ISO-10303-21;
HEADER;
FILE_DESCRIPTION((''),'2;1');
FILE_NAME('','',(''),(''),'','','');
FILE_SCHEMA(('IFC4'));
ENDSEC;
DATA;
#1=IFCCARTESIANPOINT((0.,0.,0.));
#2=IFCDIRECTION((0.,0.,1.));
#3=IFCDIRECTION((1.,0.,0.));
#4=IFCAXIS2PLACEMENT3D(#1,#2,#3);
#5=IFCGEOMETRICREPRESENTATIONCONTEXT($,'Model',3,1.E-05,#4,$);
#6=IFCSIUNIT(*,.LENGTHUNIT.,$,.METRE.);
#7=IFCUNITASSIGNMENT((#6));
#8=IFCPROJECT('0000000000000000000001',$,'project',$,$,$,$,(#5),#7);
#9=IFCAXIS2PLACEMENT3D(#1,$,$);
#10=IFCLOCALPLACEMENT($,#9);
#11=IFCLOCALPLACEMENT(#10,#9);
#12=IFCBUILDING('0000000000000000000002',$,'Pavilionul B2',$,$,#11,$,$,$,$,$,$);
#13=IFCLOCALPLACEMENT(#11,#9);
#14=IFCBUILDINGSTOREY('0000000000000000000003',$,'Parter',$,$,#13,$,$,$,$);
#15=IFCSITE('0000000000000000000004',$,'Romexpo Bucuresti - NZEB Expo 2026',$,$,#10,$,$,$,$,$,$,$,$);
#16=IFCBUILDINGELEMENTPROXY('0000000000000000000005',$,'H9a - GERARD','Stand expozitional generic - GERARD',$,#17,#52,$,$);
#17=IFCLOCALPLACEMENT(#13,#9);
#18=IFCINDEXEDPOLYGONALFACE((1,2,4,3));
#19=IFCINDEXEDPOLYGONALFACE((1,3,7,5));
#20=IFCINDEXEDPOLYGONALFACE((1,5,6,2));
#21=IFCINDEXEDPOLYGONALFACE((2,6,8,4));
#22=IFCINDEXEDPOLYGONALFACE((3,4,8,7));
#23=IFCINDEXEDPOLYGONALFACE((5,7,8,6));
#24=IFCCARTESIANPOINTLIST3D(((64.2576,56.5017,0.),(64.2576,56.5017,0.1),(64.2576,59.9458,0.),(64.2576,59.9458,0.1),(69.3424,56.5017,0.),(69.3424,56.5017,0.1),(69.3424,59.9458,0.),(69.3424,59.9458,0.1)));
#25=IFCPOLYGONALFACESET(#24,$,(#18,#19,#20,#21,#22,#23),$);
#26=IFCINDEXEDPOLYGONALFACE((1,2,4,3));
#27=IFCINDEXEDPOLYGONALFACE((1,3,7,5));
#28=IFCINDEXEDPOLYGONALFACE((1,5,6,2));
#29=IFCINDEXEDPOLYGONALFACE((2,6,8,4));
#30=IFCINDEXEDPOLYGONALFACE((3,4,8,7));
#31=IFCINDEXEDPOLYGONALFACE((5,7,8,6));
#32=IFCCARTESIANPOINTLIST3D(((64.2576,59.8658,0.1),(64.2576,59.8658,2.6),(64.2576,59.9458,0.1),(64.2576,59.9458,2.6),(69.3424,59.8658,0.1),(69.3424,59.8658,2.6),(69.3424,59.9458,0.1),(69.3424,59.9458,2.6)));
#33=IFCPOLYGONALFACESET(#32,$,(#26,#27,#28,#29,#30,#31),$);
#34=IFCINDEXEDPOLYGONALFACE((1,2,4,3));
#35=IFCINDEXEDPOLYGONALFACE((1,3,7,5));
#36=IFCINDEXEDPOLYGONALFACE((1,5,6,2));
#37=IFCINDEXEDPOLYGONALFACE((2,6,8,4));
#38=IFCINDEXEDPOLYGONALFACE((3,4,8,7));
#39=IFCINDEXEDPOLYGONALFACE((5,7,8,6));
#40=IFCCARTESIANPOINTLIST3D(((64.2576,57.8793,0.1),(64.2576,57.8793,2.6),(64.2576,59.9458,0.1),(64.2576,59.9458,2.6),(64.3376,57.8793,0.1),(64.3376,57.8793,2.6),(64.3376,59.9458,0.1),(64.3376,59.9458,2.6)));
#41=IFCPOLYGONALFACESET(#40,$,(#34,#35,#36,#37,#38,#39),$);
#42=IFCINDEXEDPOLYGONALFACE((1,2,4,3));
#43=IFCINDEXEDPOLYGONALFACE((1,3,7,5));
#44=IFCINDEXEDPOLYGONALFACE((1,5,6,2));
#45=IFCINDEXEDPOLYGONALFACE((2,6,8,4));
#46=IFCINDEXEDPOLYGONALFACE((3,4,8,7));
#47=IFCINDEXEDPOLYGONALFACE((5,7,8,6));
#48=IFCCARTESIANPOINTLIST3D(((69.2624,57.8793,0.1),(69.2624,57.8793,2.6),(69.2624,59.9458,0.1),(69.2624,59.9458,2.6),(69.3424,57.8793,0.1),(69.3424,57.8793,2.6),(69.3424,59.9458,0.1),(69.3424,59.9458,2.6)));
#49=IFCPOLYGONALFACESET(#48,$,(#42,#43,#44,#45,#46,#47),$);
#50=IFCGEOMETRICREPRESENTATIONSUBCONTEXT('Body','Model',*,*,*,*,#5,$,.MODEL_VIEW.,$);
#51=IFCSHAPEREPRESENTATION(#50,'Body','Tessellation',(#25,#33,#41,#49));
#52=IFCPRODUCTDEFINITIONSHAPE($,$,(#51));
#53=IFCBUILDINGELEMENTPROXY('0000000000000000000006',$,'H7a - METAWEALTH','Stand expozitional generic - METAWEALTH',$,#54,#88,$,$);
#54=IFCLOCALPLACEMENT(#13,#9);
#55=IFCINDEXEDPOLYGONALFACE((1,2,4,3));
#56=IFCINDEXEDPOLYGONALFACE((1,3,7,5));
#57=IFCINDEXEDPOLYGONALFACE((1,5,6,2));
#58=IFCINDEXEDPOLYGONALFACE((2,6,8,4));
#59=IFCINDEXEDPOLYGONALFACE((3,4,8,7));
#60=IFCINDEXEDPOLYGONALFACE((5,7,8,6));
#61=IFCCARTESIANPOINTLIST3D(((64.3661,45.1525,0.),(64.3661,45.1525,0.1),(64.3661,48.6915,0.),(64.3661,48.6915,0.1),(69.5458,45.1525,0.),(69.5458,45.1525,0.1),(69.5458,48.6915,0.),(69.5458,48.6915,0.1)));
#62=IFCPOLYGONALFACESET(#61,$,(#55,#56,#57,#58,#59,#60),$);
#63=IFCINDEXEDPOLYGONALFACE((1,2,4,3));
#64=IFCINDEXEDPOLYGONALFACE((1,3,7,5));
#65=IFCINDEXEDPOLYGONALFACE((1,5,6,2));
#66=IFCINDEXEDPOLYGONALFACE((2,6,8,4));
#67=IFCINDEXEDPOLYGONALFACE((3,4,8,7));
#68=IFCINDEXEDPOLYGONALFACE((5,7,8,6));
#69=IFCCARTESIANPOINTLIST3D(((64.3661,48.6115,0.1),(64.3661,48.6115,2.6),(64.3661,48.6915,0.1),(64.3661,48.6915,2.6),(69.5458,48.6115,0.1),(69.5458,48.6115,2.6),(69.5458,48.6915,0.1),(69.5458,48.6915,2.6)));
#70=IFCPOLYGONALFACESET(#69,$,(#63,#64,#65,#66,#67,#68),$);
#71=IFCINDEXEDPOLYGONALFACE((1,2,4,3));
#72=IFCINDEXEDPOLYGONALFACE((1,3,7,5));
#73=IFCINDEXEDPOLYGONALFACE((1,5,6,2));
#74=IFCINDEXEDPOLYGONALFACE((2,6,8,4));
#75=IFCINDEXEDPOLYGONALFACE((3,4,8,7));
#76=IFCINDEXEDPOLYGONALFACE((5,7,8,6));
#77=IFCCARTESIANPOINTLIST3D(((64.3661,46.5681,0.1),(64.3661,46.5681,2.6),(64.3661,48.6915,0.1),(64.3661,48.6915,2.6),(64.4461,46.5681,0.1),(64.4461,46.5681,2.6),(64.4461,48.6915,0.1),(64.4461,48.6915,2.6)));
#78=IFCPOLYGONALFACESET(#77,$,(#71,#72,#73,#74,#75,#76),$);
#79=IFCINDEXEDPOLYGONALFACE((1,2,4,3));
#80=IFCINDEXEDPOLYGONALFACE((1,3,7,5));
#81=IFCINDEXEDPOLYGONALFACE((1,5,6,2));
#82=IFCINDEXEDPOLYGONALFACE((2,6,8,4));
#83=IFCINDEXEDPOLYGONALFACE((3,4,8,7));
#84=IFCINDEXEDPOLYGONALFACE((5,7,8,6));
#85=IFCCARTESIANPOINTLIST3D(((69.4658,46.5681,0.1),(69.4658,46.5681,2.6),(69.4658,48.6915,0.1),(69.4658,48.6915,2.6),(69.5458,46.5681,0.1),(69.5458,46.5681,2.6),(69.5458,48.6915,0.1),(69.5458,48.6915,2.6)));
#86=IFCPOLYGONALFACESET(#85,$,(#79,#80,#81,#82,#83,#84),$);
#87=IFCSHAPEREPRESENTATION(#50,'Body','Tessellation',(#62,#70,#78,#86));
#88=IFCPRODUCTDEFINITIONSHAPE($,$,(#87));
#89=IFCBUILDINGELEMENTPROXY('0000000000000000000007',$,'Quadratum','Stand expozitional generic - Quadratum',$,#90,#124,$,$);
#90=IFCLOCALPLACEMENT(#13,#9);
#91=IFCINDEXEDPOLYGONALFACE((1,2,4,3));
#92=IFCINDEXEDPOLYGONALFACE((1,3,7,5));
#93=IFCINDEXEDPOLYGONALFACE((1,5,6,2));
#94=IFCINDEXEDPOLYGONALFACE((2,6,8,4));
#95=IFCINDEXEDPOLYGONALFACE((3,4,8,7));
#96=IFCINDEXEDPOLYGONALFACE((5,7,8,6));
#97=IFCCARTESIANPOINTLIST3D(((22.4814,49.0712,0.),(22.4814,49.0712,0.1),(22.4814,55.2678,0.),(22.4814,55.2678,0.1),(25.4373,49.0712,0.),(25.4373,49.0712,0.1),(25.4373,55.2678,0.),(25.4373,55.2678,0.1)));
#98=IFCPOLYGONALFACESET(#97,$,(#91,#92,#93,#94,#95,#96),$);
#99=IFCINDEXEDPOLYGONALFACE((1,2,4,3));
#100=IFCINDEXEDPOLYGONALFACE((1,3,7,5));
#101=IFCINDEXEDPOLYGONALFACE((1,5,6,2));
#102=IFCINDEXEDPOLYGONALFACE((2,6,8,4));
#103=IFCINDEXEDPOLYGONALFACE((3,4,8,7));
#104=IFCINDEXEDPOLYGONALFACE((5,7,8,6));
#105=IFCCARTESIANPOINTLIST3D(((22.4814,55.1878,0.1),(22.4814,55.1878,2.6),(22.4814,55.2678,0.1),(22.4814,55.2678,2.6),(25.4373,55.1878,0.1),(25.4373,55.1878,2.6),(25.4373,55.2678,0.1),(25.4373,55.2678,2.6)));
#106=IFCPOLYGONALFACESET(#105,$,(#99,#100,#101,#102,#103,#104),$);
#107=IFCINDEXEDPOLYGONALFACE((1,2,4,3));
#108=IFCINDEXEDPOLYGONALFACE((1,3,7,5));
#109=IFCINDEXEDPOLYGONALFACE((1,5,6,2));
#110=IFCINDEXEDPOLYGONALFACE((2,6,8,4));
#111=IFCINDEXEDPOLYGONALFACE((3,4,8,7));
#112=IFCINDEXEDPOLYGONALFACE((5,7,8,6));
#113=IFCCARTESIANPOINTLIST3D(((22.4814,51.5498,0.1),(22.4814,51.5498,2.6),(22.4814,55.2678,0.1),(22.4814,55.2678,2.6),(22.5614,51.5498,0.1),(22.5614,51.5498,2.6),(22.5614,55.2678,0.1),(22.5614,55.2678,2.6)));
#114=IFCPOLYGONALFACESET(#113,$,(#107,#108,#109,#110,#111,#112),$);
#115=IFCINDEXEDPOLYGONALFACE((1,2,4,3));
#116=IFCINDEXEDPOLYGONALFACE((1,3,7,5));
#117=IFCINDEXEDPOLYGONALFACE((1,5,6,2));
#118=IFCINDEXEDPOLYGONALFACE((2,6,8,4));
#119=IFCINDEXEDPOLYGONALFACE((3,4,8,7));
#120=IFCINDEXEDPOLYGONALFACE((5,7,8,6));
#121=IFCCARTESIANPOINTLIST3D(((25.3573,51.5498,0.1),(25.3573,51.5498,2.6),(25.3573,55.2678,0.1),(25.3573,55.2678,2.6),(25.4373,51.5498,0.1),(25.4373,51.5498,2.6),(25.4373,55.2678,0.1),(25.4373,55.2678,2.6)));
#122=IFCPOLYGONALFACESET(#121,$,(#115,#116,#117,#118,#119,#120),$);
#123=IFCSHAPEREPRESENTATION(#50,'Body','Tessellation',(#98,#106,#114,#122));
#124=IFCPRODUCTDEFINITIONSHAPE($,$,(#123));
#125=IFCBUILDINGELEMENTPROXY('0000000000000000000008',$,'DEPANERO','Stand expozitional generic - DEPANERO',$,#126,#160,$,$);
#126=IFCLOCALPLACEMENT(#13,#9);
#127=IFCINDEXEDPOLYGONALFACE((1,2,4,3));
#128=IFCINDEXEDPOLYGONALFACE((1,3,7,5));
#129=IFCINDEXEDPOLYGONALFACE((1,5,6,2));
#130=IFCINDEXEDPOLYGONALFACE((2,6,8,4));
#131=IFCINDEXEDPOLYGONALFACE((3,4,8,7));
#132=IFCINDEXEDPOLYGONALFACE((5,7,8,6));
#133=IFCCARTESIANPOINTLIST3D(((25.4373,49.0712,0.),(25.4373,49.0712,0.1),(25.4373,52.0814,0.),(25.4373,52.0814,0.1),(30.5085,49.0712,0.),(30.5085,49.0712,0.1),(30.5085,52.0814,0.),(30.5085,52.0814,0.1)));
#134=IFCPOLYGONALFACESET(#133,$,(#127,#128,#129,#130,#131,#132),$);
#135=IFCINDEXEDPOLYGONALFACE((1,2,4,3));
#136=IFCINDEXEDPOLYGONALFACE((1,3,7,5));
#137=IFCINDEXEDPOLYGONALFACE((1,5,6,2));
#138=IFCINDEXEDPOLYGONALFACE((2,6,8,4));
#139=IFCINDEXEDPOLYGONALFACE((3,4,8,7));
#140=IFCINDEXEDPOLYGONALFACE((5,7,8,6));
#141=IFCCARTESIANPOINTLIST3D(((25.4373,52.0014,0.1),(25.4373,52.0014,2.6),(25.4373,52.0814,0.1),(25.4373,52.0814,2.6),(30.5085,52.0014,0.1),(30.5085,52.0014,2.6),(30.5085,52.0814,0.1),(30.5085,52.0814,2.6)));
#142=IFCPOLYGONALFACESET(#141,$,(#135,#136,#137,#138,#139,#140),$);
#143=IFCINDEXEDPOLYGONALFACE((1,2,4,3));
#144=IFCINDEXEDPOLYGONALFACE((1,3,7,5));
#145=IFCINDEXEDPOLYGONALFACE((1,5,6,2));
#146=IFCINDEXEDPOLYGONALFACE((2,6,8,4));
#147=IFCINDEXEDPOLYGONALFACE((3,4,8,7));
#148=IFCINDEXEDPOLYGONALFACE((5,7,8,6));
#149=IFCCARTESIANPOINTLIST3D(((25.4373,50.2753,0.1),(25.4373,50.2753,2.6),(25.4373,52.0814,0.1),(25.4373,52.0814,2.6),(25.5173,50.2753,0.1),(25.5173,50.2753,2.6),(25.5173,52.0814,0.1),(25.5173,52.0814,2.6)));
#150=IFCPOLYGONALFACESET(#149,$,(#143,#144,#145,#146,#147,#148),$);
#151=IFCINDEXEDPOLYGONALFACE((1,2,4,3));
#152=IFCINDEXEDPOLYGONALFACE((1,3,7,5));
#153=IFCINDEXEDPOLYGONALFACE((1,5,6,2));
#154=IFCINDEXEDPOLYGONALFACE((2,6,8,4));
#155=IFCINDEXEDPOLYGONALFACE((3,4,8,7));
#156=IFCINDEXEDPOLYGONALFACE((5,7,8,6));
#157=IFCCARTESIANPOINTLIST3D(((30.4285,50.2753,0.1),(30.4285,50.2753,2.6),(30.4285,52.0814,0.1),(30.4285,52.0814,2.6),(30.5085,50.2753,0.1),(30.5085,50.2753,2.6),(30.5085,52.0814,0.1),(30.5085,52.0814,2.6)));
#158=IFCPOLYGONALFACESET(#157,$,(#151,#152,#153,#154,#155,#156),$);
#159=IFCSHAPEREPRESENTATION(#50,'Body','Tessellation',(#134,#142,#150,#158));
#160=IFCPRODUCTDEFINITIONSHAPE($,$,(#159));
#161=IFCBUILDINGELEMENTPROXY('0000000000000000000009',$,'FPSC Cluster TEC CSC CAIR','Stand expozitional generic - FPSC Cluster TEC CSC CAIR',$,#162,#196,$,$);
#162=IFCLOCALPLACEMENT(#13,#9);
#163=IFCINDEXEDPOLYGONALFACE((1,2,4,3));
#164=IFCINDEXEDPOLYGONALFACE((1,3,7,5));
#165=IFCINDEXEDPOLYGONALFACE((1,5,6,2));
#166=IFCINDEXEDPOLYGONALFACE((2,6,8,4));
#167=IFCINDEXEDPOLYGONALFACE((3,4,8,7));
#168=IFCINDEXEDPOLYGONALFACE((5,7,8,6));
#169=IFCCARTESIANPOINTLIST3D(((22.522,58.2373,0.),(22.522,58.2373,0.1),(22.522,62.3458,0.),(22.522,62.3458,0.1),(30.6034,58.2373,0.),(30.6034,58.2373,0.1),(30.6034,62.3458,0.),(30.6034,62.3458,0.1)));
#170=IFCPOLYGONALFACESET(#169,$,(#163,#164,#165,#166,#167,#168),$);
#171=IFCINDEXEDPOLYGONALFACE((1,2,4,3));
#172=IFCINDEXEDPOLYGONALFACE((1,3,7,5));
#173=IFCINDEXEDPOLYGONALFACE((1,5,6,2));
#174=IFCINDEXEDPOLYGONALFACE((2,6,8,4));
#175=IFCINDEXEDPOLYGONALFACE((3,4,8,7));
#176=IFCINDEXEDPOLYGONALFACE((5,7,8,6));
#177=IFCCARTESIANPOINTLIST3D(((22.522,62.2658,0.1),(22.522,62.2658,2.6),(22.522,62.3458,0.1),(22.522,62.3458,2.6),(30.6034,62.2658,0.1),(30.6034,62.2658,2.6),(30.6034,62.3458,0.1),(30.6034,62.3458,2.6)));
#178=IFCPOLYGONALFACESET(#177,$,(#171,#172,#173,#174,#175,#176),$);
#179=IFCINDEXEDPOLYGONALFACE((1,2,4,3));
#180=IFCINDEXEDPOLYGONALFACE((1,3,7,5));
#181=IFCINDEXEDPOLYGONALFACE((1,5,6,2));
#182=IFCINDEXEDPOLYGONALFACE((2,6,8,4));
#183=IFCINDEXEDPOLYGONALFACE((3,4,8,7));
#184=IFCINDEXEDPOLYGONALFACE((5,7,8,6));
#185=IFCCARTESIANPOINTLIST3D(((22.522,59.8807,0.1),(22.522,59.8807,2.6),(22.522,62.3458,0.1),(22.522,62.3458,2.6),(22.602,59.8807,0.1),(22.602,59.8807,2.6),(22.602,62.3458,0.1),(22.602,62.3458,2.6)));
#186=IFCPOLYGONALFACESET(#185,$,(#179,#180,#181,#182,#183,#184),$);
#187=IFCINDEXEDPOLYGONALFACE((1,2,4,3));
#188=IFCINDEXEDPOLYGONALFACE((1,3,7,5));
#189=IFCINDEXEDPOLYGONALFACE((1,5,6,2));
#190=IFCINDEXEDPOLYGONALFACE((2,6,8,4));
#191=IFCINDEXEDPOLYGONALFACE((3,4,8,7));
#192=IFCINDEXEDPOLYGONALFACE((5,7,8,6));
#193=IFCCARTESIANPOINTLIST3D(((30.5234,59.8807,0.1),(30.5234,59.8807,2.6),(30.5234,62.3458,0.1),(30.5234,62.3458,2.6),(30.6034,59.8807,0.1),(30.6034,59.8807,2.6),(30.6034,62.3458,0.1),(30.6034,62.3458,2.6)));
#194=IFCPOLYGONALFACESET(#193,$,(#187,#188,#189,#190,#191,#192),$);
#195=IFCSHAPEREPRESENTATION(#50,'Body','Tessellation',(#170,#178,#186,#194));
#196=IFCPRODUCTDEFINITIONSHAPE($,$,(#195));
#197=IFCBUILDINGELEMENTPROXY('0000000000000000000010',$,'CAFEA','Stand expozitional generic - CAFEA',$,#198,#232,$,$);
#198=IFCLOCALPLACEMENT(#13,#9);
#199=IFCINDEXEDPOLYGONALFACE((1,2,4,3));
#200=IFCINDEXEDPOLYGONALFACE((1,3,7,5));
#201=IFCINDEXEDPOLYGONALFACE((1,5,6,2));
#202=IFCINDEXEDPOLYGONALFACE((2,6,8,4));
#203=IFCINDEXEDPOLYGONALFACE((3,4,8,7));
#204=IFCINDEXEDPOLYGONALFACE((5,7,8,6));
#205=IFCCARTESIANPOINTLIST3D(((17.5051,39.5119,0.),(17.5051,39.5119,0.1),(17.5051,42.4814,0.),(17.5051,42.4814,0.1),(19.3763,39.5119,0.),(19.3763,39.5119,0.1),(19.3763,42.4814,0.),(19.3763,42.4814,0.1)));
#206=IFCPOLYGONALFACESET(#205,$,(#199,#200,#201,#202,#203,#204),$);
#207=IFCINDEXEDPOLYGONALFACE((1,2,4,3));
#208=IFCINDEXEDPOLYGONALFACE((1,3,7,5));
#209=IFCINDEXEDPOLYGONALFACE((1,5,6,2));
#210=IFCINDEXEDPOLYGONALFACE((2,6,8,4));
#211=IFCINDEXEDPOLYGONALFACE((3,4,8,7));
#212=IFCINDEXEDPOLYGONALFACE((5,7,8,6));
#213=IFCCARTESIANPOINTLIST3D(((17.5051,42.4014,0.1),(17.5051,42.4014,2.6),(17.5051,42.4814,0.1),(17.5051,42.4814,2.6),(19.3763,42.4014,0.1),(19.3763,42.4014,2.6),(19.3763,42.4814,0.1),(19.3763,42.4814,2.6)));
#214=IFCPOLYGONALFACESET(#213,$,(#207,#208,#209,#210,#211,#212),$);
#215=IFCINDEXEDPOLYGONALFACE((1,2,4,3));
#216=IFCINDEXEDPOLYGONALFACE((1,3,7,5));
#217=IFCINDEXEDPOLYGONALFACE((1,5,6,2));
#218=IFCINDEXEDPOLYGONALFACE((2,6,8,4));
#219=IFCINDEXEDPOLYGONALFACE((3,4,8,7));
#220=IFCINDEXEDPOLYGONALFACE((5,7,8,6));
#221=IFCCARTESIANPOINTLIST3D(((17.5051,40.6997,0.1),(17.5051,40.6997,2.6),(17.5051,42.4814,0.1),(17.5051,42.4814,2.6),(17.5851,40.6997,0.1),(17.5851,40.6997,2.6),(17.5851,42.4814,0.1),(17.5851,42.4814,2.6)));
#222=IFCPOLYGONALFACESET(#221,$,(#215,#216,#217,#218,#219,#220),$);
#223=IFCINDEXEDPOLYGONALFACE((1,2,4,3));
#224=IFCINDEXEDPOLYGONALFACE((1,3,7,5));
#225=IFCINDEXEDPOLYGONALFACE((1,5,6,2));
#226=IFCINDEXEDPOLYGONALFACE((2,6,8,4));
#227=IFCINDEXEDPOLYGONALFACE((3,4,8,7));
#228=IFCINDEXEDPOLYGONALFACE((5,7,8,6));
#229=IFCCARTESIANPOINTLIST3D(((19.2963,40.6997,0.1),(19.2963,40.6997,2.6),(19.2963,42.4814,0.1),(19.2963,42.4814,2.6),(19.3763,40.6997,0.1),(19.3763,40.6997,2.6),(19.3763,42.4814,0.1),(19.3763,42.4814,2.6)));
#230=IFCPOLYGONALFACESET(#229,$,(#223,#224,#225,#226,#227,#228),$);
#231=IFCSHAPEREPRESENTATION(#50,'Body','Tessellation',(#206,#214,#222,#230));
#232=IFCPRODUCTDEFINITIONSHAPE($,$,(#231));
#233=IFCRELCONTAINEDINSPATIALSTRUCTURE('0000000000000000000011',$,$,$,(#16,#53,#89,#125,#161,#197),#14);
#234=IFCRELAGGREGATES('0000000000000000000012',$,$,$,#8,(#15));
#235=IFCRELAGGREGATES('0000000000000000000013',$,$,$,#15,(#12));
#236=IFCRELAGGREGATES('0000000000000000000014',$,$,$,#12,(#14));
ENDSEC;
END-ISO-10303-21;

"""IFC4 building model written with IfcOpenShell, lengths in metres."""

from ifc_helpers import new_model, si_unit, frame, frame_2d, origin, origin_with_axes, place, context, subcontext, project, spatial, rectangle, extrude, element, save


model = new_model("IFC4")

# Units and contexts
model_context = context("Model", 3, precision=1e-05, world=origin_with_axes())
body_context = subcontext(model_context, "Body", "Model", "MODEL_VIEW")
ifc_project = project(units=[si_unit("LENGTHUNIT", "METRE")], contexts=[model_context])

# Site, building, storey
site_placement = place(None, origin())
site = spatial("IfcSite", under=ifc_project, at=site_placement, Name="Romexpo Bucuresti - NZEB Expo 2026")
building_placement = place(site_placement, origin())
building = spatial("IfcBuilding", under=site, at=building_placement, Name="Pavilionul B2")
storey_placement = place(building_placement, origin())
storey = spatial("IfcBuildingStorey", under=building, at=storey_placement, Name="Parter")

# Building element proxies
proxy_1_placement = place(storey_placement, frame((64.2576, 56.5017, 0.0), z_axis=(0.0, 0.0, 1.0), x_axis=(1.0, 0.0, 0.0)))
element("IfcBuildingElementProxy", 1, at=proxy_1_placement, inside=storey, Name="H9a - GERARD", Description="Stand expozitional generic - GERARD", context=body_context, shape_type="SweptSolid", body=[
    extrude(rectangle(XDim=5.0847, YDim=3.4441, at=frame_2d((2.5424, 1.722))), origin(), (0.0, 0.0, 1.0), 0.1),
    extrude(rectangle(XDim=5.0847, YDim=0.08, at=frame_2d((2.5424, 3.4041))), frame((0.0, 0.0, 0.1)), (0.0, 0.0, 1.0), 2.5),
    extrude(rectangle(XDim=0.08, YDim=2.0664, at=frame_2d((0.04, 2.4108))), frame((0.0, 0.0, 0.1)), (0.0, 0.0, 1.0), 2.5),
    extrude(rectangle(XDim=0.08, YDim=2.0664, at=frame_2d((5.0447, 2.4108))), frame((0.0, 0.0, 0.1)), (0.0, 0.0, 1.0), 2.5),
])
proxy_2_placement = place(storey_placement, frame((64.3661, 45.1525, 0.0), z_axis=(0.0, 0.0, 1.0), x_axis=(1.0, 0.0, 0.0)))
element("IfcBuildingElementProxy", 2, at=proxy_2_placement, inside=storey, Name="H7a - METAWEALTH", Description="Stand expozitional generic - METAWEALTH", context=body_context, shape_type="SweptSolid", body=[
    extrude(rectangle(XDim=5.1797, YDim=3.539, at=frame_2d((2.5898, 1.7695))), origin(), (0.0, 0.0, 1.0), 0.1),
    extrude(rectangle(XDim=5.1797, YDim=0.08, at=frame_2d((2.5898, 3.499))), frame((0.0, 0.0, 0.1)), (0.0, 0.0, 1.0), 2.5),
    extrude(rectangle(XDim=0.08, YDim=2.1234, at=frame_2d((0.04, 2.4773))), frame((0.0, 0.0, 0.1)), (0.0, 0.0, 1.0), 2.5),
    extrude(rectangle(XDim=0.08, YDim=2.1234, at=frame_2d((5.1397, 2.4773))), frame((0.0, 0.0, 0.1)), (0.0, 0.0, 1.0), 2.5),
])
proxy_3_placement = place(storey_placement, frame((22.4814, 49.0712, 0.0), z_axis=(0.0, 0.0, 1.0), x_axis=(1.0, 0.0, 0.0)))
element("IfcBuildingElementProxy", 3, at=proxy_3_placement, inside=storey, Name="Quadratum", Description="Stand expozitional generic - Quadratum", context=body_context, shape_type="SweptSolid", body=[
    extrude(rectangle(XDim=2.9559, YDim=6.1966, at=frame_2d((1.478, 3.0983))), origin(), (0.0, 0.0, 1.0), 0.1),
    extrude(rectangle(XDim=2.9559, YDim=0.08, at=frame_2d((1.478, 6.1566))), frame((0.0, 0.0, 0.1)), (0.0, 0.0, 1.0), 2.5),
    extrude(rectangle(XDim=0.08, YDim=3.718, at=frame_2d((0.04, 4.3376))), frame((0.0, 0.0, 0.1)), (0.0, 0.0, 1.0), 2.5),
    extrude(rectangle(XDim=0.08, YDim=3.718, at=frame_2d((2.9159, 4.3376))), frame((0.0, 0.0, 0.1)), (0.0, 0.0, 1.0), 2.5),
])
proxy_4_placement = place(storey_placement, frame((25.4373, 49.0712, 0.0), z_axis=(0.0, 0.0, 1.0), x_axis=(1.0, 0.0, 0.0)))
element("IfcBuildingElementProxy", 4, at=proxy_4_placement, inside=storey, Name="DEPANERO", Description="Stand expozitional generic - DEPANERO", context=body_context, shape_type="SweptSolid", body=[
    extrude(rectangle(XDim=5.0712, YDim=3.0102, at=frame_2d((2.5356, 1.5051))), origin(), (0.0, 0.0, 1.0), 0.1),
    extrude(rectangle(XDim=5.0712, YDim=0.08, at=frame_2d((2.5356, 2.9702))), frame((0.0, 0.0, 0.1)), (0.0, 0.0, 1.0), 2.5),
    extrude(rectangle(XDim=0.08, YDim=1.8061, at=frame_2d((0.04, 2.1071))), frame((0.0, 0.0, 0.1)), (0.0, 0.0, 1.0), 2.5),
    extrude(rectangle(XDim=0.08, YDim=1.8061, at=frame_2d((5.0312, 2.1071))), frame((0.0, 0.0, 0.1)), (0.0, 0.0, 1.0), 2.5),
])
proxy_5_placement = place(storey_placement, frame((22.522, 58.2373, 0.0), z_axis=(0.0, 0.0, 1.0), x_axis=(1.0, 0.0, 0.0)))
element("IfcBuildingElementProxy", 5, at=proxy_5_placement, inside=storey, Name="FPSC Cluster TEC CSC CAIR", Description="Stand expozitional generic - FPSC Cluster TEC CSC CAIR", context=body_context, shape_type="SweptSolid", body=[
    extrude(rectangle(XDim=8.0814, YDim=4.1085, at=frame_2d((4.0407, 2.0542))), origin(), (0.0, 0.0, 1.0), 0.1),
    extrude(rectangle(XDim=8.0814, YDim=0.08, at=frame_2d((4.0407, 4.0685))), frame((0.0, 0.0, 0.1)), (0.0, 0.0, 1.0), 2.5),
    extrude(rectangle(XDim=0.08, YDim=2.4651, at=frame_2d((0.04, 2.8759))), frame((0.0, 0.0, 0.1)), (0.0, 0.0, 1.0), 2.5),
    extrude(rectangle(XDim=0.08, YDim=2.4651, at=frame_2d((8.0414, 2.8759))), frame((0.0, 0.0, 0.1)), (0.0, 0.0, 1.0), 2.5),
])
proxy_6_placement = place(storey_placement, frame((17.5051, 39.5119, 0.0), z_axis=(0.0, 0.0, 1.0), x_axis=(1.0, 0.0, 0.0)))
element("IfcBuildingElementProxy", 6, at=proxy_6_placement, inside=storey, Name="CAFEA", Description="Stand expozitional generic - CAFEA", context=body_context, shape_type="SweptSolid", body=[
    extrude(rectangle(XDim=1.8712, YDim=2.9695, at=frame_2d((0.9356, 1.4847))), origin(), (0.0, 0.0, 1.0), 0.1),
    extrude(rectangle(XDim=1.8712, YDim=0.08, at=frame_2d((0.9356, 2.9295))), frame((0.0, 0.0, 0.1)), (0.0, 0.0, 1.0), 2.5),
    extrude(rectangle(XDim=0.08, YDim=1.7817, at=frame_2d((0.04, 2.0786))), frame((0.0, 0.0, 0.1)), (0.0, 0.0, 1.0), 2.5),
    extrude(rectangle(XDim=0.08, YDim=1.7817, at=frame_2d((1.8312, 2.0786))), frame((0.0, 0.0, 0.1)), (0.0, 0.0, 1.0), 2.5),
])

save(model, "model.ifc")
